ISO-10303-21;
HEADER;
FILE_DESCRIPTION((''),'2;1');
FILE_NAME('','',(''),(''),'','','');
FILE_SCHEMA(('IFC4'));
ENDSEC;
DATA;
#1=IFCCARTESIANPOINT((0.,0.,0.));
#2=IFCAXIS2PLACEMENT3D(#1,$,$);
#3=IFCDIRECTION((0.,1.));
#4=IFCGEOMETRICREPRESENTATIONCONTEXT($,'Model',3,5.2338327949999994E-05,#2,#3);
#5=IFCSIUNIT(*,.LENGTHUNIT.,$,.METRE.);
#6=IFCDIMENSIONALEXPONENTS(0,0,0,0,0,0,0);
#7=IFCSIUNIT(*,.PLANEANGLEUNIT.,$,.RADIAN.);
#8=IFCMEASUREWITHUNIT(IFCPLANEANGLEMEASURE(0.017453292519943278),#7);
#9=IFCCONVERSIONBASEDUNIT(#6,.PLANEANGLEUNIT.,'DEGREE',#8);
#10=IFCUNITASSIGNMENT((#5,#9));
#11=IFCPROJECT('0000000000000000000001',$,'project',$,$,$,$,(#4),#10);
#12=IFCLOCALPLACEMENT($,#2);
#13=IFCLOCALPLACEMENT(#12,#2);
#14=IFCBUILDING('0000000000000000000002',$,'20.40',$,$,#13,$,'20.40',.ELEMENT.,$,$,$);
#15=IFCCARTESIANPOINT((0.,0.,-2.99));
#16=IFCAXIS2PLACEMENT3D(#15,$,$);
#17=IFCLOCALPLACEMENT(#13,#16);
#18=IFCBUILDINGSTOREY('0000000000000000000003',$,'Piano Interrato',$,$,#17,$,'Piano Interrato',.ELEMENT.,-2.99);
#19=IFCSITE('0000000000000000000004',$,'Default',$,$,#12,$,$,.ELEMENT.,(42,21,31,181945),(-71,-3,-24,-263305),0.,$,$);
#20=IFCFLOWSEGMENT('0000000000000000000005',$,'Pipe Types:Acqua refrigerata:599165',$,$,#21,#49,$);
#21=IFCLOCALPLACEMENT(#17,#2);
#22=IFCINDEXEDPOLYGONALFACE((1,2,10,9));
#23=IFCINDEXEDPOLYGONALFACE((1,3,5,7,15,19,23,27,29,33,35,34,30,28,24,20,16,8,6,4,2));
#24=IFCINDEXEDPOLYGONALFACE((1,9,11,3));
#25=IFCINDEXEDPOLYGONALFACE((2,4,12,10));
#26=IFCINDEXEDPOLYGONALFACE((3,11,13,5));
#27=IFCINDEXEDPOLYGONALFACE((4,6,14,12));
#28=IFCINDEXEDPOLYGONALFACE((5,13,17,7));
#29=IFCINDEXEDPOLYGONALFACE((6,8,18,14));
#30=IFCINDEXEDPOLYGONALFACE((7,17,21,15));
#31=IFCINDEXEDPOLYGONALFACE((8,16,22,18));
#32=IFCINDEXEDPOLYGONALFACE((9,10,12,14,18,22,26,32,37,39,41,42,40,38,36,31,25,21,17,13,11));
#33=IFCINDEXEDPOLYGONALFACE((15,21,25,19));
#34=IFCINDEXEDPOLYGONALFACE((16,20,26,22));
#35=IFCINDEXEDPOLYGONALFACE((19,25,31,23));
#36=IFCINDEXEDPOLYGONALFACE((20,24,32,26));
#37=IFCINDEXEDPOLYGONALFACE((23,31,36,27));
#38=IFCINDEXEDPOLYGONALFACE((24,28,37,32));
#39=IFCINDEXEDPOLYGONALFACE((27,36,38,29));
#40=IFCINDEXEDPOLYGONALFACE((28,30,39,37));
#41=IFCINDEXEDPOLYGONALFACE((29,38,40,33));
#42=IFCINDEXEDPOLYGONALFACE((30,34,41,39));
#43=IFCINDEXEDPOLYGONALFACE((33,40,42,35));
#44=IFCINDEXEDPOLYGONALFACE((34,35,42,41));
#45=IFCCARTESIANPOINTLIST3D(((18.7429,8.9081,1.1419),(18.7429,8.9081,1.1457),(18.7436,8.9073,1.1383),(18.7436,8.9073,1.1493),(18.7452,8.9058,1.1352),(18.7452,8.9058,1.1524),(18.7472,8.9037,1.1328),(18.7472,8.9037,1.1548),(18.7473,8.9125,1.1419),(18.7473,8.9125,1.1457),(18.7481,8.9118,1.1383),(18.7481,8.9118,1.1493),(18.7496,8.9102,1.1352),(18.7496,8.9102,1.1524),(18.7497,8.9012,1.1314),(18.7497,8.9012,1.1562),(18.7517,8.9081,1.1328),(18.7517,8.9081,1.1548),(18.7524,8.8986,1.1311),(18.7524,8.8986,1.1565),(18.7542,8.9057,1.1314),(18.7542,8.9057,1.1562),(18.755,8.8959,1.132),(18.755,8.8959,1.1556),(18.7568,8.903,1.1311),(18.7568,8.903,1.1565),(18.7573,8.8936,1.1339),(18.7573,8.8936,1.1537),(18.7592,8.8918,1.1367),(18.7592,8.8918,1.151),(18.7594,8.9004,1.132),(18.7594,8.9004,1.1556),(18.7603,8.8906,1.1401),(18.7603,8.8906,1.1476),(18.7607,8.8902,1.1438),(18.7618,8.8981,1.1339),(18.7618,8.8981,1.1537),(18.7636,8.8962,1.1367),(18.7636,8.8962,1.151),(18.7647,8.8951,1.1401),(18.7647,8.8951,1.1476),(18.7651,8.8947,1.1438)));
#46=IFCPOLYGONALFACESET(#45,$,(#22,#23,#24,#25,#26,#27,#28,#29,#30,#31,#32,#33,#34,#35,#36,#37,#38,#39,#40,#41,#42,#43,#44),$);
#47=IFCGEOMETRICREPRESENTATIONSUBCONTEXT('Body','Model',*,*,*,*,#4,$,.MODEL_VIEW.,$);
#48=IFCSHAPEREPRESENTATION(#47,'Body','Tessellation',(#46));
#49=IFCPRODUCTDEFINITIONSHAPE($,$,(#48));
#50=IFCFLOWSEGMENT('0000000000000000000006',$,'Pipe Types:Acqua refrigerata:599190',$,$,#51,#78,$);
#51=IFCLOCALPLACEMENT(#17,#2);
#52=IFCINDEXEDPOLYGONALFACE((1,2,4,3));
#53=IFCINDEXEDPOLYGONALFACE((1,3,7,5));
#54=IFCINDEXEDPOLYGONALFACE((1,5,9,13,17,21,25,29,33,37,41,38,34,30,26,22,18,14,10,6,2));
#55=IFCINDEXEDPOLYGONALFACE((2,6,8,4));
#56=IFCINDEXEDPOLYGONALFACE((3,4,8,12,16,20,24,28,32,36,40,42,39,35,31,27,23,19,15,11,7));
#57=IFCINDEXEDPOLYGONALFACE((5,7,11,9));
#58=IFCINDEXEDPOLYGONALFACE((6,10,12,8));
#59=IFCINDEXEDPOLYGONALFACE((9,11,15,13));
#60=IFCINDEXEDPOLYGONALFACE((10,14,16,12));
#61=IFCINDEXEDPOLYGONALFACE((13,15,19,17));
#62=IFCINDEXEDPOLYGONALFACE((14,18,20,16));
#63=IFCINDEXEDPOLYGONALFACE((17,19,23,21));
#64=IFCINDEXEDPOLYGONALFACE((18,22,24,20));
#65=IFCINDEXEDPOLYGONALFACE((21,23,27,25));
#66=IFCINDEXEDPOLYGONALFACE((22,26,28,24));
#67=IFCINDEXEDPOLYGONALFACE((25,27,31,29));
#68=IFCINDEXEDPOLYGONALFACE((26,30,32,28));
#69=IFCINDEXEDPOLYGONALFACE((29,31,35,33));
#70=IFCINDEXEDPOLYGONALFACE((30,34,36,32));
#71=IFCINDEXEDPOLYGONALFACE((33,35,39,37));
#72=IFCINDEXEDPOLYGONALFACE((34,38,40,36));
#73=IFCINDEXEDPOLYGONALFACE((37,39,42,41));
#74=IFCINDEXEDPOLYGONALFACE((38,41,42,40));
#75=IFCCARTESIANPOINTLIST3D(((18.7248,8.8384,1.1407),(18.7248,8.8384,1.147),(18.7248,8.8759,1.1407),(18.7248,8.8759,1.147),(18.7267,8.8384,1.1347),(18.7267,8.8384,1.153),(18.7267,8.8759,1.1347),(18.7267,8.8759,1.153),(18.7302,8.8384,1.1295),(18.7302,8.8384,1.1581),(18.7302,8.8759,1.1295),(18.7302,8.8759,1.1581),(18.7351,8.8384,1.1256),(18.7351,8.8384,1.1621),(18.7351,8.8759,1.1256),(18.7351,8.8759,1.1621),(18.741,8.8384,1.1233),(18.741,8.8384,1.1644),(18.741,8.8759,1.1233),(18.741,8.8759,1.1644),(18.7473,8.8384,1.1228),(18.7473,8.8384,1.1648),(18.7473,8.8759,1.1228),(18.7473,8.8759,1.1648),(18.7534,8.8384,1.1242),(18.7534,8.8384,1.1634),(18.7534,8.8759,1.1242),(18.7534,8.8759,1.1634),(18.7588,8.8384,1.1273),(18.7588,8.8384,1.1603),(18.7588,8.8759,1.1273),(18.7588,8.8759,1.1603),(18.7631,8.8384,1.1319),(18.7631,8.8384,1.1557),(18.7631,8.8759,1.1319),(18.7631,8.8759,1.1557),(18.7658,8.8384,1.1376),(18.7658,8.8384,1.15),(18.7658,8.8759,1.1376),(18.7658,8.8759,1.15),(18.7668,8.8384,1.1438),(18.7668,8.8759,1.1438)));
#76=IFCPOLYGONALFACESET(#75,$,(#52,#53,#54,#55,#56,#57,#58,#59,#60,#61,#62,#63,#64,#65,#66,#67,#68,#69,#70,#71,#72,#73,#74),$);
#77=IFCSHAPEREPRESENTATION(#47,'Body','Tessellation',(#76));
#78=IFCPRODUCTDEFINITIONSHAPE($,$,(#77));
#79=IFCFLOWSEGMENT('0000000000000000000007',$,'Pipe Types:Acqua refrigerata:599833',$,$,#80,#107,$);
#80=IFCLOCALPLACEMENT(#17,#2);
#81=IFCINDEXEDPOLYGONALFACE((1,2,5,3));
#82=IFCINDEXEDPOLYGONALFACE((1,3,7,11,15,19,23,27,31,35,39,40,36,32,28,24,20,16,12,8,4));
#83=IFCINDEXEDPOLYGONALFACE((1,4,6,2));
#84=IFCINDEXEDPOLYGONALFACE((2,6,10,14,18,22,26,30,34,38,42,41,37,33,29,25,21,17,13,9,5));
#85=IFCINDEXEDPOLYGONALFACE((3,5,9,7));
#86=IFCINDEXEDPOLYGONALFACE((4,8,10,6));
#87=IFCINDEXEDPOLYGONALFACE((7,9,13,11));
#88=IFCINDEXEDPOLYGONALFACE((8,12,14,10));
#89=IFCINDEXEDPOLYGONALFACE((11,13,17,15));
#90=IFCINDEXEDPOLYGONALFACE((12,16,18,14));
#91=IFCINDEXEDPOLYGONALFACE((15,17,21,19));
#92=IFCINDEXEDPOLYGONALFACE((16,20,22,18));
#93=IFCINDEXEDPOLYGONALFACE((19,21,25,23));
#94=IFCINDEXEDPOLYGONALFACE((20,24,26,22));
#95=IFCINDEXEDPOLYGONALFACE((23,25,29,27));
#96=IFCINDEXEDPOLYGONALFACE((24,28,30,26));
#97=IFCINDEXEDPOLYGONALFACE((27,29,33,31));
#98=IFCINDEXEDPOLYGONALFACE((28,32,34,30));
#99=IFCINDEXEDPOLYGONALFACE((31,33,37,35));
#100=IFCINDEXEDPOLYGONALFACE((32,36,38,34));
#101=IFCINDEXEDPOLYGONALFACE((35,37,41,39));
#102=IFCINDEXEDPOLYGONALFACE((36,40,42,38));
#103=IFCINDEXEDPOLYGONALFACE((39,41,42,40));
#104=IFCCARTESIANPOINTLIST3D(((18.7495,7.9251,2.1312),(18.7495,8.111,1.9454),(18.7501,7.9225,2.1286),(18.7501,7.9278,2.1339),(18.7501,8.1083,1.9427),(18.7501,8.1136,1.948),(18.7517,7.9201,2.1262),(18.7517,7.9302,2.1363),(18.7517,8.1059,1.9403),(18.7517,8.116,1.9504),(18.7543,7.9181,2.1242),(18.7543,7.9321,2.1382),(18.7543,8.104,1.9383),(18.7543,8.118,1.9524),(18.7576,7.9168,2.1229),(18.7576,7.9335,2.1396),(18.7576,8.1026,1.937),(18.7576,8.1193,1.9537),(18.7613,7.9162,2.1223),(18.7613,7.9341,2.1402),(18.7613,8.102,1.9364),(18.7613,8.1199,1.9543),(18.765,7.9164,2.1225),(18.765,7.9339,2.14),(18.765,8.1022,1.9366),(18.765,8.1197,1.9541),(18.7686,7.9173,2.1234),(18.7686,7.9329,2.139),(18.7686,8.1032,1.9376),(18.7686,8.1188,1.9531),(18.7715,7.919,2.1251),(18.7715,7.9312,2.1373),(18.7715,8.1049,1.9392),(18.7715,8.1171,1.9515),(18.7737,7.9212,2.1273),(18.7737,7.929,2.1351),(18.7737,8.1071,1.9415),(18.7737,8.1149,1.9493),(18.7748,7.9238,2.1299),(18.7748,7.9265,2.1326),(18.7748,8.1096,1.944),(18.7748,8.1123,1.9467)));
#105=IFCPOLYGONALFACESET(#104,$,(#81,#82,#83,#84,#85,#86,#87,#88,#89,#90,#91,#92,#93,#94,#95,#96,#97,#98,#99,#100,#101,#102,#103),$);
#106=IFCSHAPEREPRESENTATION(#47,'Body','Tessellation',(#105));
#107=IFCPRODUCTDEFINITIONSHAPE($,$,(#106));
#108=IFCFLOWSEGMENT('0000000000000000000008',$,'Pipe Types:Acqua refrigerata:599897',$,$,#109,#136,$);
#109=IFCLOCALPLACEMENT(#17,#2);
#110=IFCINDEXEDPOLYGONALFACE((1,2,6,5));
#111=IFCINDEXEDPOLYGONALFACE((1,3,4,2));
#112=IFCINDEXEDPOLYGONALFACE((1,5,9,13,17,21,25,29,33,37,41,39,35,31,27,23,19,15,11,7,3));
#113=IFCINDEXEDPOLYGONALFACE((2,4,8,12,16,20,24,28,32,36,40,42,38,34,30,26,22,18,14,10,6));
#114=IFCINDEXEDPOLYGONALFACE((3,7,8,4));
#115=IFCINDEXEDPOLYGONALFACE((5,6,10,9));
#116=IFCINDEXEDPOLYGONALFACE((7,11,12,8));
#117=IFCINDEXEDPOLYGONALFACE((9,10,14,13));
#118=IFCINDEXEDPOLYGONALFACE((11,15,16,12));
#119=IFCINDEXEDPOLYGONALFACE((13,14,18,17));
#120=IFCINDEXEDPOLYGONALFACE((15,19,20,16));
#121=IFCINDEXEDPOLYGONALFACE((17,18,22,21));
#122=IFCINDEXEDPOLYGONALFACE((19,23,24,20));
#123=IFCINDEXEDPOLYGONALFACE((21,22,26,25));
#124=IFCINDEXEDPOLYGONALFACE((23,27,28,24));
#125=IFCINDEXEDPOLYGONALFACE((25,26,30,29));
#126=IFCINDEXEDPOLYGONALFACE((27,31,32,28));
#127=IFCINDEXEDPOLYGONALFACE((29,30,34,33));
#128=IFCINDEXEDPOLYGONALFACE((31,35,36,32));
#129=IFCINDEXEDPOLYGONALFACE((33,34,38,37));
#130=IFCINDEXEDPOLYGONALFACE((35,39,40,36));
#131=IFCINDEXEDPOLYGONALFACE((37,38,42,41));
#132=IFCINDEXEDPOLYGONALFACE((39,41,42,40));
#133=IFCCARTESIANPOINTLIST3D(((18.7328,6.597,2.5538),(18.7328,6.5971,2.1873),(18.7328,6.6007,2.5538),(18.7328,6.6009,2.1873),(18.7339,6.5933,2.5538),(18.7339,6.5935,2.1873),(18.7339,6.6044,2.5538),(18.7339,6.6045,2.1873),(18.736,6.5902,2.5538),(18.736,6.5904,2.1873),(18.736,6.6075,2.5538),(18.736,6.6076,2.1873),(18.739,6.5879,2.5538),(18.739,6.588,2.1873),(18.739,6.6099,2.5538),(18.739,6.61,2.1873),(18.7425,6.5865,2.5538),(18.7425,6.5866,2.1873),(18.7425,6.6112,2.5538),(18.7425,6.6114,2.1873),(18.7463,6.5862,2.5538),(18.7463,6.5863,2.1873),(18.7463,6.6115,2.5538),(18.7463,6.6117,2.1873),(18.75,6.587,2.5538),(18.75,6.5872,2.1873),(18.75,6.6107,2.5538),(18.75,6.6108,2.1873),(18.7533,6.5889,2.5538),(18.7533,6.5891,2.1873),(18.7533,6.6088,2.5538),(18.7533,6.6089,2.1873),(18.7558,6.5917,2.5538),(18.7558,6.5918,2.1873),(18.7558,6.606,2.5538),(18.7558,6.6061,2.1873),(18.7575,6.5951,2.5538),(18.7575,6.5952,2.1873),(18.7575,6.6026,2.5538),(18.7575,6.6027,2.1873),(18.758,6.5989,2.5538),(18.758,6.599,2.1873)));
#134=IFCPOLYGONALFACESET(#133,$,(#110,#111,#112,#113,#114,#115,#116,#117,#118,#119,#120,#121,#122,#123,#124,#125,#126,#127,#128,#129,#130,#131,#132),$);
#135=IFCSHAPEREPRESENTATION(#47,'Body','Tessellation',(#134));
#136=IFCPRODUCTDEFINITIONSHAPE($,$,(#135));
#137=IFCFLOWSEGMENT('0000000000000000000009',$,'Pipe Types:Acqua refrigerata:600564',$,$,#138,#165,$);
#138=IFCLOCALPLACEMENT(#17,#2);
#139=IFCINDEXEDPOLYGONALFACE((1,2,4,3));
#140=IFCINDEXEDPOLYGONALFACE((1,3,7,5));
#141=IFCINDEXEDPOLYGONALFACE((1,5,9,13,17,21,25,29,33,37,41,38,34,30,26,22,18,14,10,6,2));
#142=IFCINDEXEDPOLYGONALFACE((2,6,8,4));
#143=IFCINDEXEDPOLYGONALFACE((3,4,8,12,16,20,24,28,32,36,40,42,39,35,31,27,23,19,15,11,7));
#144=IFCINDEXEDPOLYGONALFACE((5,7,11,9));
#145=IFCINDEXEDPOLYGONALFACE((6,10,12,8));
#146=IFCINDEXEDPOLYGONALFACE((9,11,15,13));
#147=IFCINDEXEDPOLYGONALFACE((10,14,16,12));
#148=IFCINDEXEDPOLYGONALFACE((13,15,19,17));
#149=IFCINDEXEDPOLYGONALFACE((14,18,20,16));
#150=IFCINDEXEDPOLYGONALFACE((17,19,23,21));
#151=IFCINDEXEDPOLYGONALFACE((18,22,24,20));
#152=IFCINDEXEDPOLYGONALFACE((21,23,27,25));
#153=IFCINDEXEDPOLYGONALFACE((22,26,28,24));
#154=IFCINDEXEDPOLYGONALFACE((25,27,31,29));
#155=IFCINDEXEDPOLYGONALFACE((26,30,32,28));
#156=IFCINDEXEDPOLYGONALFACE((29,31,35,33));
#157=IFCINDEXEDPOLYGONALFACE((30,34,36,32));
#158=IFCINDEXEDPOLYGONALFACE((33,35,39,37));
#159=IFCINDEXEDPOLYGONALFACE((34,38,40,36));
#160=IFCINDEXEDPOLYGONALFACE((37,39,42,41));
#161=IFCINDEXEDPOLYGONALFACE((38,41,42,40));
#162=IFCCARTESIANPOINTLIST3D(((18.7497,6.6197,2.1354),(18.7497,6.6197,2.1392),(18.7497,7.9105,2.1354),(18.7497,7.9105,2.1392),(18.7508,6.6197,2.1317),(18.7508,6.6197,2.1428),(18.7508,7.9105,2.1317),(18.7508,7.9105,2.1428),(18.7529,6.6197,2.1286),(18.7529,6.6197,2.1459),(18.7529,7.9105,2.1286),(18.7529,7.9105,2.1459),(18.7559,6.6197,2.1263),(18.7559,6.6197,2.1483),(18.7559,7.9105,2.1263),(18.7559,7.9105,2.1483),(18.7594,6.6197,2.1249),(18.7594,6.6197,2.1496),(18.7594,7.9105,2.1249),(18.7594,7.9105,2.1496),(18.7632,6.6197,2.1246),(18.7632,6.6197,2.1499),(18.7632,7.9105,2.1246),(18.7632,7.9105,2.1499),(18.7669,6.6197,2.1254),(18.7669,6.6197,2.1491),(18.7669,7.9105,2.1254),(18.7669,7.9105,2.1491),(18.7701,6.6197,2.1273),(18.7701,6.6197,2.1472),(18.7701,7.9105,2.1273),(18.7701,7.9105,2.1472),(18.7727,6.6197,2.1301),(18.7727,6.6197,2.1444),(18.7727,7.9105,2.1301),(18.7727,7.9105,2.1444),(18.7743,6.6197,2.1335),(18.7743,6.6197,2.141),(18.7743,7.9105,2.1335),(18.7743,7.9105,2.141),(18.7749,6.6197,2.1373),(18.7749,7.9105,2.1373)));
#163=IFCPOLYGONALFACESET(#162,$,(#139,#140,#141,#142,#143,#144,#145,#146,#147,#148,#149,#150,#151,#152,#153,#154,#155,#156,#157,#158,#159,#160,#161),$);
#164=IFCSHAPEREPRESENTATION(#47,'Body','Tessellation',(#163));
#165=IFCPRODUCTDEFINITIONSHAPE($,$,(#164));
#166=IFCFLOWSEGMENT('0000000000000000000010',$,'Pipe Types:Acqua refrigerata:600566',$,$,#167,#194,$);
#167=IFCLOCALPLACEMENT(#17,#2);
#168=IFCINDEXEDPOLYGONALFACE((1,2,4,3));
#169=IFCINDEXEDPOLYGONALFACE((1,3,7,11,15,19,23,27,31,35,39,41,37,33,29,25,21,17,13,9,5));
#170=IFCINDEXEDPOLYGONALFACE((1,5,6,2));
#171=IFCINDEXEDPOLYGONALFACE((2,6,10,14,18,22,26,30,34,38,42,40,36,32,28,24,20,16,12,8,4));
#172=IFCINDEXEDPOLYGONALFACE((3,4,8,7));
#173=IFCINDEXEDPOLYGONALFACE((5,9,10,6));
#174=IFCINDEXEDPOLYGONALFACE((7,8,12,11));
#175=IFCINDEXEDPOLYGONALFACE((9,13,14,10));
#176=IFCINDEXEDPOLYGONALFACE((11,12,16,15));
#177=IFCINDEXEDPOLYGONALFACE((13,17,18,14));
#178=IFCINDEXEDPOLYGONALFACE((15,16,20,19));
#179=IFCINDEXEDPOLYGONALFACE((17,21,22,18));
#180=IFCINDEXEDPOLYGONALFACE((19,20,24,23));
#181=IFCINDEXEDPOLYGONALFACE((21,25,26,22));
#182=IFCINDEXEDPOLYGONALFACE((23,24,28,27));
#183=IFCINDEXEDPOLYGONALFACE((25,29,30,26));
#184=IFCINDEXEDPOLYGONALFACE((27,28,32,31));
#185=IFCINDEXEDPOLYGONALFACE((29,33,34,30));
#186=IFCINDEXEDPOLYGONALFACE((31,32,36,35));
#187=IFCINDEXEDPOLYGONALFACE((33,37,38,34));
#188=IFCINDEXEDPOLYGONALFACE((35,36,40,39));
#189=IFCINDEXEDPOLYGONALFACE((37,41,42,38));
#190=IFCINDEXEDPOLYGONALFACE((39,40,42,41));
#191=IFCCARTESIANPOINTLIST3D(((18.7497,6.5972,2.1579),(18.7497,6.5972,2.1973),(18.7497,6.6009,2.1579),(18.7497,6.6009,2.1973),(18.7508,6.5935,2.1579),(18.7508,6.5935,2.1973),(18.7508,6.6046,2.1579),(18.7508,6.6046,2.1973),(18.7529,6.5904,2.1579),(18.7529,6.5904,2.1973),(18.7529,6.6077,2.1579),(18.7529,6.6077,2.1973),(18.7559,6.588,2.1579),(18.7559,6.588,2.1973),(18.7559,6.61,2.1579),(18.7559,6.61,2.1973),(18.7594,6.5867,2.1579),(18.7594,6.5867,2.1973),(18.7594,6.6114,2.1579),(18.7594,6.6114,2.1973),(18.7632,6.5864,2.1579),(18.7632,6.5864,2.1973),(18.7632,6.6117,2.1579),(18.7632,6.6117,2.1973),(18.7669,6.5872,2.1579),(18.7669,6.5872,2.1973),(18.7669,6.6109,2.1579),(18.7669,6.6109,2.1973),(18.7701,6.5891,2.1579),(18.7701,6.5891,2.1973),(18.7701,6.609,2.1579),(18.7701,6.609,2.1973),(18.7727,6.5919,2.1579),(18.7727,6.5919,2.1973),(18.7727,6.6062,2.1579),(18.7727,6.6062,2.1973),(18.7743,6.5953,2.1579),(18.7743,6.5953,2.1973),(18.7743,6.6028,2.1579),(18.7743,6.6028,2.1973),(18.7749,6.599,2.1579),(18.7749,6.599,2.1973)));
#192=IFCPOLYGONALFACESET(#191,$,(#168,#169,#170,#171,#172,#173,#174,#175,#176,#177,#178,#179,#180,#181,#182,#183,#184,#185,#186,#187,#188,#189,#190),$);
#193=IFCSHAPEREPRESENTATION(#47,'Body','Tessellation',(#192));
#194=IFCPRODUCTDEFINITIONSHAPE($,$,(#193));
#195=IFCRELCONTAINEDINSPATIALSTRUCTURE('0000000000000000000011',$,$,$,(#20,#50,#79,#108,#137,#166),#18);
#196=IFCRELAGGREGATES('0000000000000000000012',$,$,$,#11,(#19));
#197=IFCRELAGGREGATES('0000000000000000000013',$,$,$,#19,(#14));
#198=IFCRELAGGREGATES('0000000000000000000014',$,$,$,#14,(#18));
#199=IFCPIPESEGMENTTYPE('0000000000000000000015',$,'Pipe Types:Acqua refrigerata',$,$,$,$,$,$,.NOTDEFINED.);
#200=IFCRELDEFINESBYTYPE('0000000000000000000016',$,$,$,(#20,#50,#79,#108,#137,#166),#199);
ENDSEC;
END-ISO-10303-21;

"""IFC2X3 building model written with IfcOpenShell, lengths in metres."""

from ifc_helpers import new_model, entity, si_unit, converted_unit, direction, frame, frame_2d, origin, origin_2d_with_axis, place, context, subcontext, project, spatial, circle, extrude, type_object, element, save


model = new_model("IFC2X3")

# Units and contexts
model_context = context("Model", 3, precision=5.2338327949999994e-05, world=origin(), true_north=direction((0.0, 1.0)))
body_context = subcontext(model_context, "Body", "Model", "MODEL_VIEW")
ifc_project = project(units=[si_unit("LENGTHUNIT", "METRE"), converted_unit("PLANEANGLEUNIT", "DEGREE", entity("IfcPlaneAngleMeasure", 0.017453292519943278), si_unit("PLANEANGLEUNIT", "RADIAN"), dimensions=[0, 0, 0, 0, 0, 0, 0])], contexts=[model_context])

# Site, building, storey
site_placement = place(None, origin())
site = spatial("IfcSite", under=ifc_project, at=site_placement, Name="Default", CompositionType="ELEMENT", RefLatitude=(42, 21, 31, 181945), RefLongitude=(-71, -3, -24, -263305), RefElevation=0.0)
building_placement = place(site_placement, origin())
building = spatial("IfcBuilding", under=site, at=building_placement, Name="20.40", LongName="20.40", CompositionType="ELEMENT")
storey_placement = place(building_placement, frame((0.0, 0.0, -2.99)))
storey = spatial("IfcBuildingStorey", under=building, at=storey_placement, Name="Piano Interrato", LongName="Piano Interrato", CompositionType="ELEMENT", Elevation=-2.99)

# Flow segments
pipe_segment_type_1 = type_object("IfcPipeSegmentType", Name="Pipe Types:Acqua refrigerata", PredefinedType="NOTDEFINED")
flow_segment_1_placement = place(storey_placement, origin())
element("IfcFlowSegment", 1, at=flow_segment_1_placement, inside=storey, type_object=pipe_segment_type_1, Name="Pipe Types:Acqua refrigerata:599165", context=body_context, shape_type="SweptSolid", body=[
    extrude(circle(Radius=0.0127, at=frame_2d((0.0, 0.0), x_axis=(1.0, 0.0))), frame((18.7517, 8.8992, 1.1438), z_axis=(0.707113, 0.707101, 0.0), x_axis=(0.707101, -0.707113, 0.0)), (0.0, 0.0, 1.0), 0.0063),
])
flow_segment_2_placement = place(storey_placement, origin())
element("IfcFlowSegment", 2, at=flow_segment_2_placement, inside=storey, type_object=pipe_segment_type_1, Name="Pipe Types:Acqua refrigerata:599190", context=body_context, shape_type="SweptSolid", body=[
    extrude(circle(Radius=0.0211, at=origin_2d_with_axis()), frame((18.7457, 8.8384, 1.1438), z_axis=(0.0, 1.0, 0.0), x_axis=(1.0, 0.0, 0.0)), (0.0, 0.0, 1.0), 0.0375),
])
flow_segment_3_placement = place(storey_placement, origin())
element("IfcFlowSegment", 3, at=flow_segment_3_placement, inside=storey, type_object=pipe_segment_type_1, Name="Pipe Types:Acqua refrigerata:599833", context=body_context, shape_type="SweptSolid", body=[
    extrude(circle(Radius=0.0127, at=frame_2d((0.0, 0.0), x_axis=(1.0, 0.0))), frame((18.7622, 8.111, 1.9454), z_axis=(0.0, -0.707107, 0.707107), x_axis=(-1.0, 0.0, 0.0)), (0.0, 0.0, 1.0), 0.2628),
])
flow_segment_4_placement = place(storey_placement, origin())
element("IfcFlowSegment", 4, at=flow_segment_4_placement, inside=storey, type_object=pipe_segment_type_1, Name="Pipe Types:Acqua refrigerata:599897", context=body_context, shape_type="SweptSolid", body=[
    extrude(circle(Radius=0.0127, at=frame_2d((0.0, 0.0), x_axis=(1.0, 0.0))), frame((18.7453, 6.599, 2.1873), z_axis=(0.0, -0.000383, 1.0), x_axis=(1.0, 0.0, 0.0)), (0.0, 0.0, 1.0), 0.3665),
])
flow_segment_5_placement = place(storey_placement, origin())
element("IfcFlowSegment", 5, at=flow_segment_5_placement, inside=storey, type_object=pipe_segment_type_1, Name="Pipe Types:Acqua refrigerata:600564", context=body_context, shape_type="SweptSolid", body=[
    extrude(circle(Radius=0.0127, at=origin_2d_with_axis()), frame((18.7622, 6.6197, 2.1373), z_axis=(0.0, 1.0, 0.0), x_axis=(1.0, 0.0, 0.0)), (0.0, 0.0, 1.0), 1.2908),
])
flow_segment_6_placement = place(storey_placement, origin())
element("IfcFlowSegment", 6, at=flow_segment_6_placement, inside=storey, type_object=pipe_segment_type_1, Name="Pipe Types:Acqua refrigerata:600566", context=body_context, shape_type="SweptSolid", body=[
    extrude(circle(Radius=0.0127, at=origin_2d_with_axis()), frame((18.7622, 6.599, 2.1579)), (0.0, 0.0, 1.0), 0.0394),
])

save(model, "model.ifc")
